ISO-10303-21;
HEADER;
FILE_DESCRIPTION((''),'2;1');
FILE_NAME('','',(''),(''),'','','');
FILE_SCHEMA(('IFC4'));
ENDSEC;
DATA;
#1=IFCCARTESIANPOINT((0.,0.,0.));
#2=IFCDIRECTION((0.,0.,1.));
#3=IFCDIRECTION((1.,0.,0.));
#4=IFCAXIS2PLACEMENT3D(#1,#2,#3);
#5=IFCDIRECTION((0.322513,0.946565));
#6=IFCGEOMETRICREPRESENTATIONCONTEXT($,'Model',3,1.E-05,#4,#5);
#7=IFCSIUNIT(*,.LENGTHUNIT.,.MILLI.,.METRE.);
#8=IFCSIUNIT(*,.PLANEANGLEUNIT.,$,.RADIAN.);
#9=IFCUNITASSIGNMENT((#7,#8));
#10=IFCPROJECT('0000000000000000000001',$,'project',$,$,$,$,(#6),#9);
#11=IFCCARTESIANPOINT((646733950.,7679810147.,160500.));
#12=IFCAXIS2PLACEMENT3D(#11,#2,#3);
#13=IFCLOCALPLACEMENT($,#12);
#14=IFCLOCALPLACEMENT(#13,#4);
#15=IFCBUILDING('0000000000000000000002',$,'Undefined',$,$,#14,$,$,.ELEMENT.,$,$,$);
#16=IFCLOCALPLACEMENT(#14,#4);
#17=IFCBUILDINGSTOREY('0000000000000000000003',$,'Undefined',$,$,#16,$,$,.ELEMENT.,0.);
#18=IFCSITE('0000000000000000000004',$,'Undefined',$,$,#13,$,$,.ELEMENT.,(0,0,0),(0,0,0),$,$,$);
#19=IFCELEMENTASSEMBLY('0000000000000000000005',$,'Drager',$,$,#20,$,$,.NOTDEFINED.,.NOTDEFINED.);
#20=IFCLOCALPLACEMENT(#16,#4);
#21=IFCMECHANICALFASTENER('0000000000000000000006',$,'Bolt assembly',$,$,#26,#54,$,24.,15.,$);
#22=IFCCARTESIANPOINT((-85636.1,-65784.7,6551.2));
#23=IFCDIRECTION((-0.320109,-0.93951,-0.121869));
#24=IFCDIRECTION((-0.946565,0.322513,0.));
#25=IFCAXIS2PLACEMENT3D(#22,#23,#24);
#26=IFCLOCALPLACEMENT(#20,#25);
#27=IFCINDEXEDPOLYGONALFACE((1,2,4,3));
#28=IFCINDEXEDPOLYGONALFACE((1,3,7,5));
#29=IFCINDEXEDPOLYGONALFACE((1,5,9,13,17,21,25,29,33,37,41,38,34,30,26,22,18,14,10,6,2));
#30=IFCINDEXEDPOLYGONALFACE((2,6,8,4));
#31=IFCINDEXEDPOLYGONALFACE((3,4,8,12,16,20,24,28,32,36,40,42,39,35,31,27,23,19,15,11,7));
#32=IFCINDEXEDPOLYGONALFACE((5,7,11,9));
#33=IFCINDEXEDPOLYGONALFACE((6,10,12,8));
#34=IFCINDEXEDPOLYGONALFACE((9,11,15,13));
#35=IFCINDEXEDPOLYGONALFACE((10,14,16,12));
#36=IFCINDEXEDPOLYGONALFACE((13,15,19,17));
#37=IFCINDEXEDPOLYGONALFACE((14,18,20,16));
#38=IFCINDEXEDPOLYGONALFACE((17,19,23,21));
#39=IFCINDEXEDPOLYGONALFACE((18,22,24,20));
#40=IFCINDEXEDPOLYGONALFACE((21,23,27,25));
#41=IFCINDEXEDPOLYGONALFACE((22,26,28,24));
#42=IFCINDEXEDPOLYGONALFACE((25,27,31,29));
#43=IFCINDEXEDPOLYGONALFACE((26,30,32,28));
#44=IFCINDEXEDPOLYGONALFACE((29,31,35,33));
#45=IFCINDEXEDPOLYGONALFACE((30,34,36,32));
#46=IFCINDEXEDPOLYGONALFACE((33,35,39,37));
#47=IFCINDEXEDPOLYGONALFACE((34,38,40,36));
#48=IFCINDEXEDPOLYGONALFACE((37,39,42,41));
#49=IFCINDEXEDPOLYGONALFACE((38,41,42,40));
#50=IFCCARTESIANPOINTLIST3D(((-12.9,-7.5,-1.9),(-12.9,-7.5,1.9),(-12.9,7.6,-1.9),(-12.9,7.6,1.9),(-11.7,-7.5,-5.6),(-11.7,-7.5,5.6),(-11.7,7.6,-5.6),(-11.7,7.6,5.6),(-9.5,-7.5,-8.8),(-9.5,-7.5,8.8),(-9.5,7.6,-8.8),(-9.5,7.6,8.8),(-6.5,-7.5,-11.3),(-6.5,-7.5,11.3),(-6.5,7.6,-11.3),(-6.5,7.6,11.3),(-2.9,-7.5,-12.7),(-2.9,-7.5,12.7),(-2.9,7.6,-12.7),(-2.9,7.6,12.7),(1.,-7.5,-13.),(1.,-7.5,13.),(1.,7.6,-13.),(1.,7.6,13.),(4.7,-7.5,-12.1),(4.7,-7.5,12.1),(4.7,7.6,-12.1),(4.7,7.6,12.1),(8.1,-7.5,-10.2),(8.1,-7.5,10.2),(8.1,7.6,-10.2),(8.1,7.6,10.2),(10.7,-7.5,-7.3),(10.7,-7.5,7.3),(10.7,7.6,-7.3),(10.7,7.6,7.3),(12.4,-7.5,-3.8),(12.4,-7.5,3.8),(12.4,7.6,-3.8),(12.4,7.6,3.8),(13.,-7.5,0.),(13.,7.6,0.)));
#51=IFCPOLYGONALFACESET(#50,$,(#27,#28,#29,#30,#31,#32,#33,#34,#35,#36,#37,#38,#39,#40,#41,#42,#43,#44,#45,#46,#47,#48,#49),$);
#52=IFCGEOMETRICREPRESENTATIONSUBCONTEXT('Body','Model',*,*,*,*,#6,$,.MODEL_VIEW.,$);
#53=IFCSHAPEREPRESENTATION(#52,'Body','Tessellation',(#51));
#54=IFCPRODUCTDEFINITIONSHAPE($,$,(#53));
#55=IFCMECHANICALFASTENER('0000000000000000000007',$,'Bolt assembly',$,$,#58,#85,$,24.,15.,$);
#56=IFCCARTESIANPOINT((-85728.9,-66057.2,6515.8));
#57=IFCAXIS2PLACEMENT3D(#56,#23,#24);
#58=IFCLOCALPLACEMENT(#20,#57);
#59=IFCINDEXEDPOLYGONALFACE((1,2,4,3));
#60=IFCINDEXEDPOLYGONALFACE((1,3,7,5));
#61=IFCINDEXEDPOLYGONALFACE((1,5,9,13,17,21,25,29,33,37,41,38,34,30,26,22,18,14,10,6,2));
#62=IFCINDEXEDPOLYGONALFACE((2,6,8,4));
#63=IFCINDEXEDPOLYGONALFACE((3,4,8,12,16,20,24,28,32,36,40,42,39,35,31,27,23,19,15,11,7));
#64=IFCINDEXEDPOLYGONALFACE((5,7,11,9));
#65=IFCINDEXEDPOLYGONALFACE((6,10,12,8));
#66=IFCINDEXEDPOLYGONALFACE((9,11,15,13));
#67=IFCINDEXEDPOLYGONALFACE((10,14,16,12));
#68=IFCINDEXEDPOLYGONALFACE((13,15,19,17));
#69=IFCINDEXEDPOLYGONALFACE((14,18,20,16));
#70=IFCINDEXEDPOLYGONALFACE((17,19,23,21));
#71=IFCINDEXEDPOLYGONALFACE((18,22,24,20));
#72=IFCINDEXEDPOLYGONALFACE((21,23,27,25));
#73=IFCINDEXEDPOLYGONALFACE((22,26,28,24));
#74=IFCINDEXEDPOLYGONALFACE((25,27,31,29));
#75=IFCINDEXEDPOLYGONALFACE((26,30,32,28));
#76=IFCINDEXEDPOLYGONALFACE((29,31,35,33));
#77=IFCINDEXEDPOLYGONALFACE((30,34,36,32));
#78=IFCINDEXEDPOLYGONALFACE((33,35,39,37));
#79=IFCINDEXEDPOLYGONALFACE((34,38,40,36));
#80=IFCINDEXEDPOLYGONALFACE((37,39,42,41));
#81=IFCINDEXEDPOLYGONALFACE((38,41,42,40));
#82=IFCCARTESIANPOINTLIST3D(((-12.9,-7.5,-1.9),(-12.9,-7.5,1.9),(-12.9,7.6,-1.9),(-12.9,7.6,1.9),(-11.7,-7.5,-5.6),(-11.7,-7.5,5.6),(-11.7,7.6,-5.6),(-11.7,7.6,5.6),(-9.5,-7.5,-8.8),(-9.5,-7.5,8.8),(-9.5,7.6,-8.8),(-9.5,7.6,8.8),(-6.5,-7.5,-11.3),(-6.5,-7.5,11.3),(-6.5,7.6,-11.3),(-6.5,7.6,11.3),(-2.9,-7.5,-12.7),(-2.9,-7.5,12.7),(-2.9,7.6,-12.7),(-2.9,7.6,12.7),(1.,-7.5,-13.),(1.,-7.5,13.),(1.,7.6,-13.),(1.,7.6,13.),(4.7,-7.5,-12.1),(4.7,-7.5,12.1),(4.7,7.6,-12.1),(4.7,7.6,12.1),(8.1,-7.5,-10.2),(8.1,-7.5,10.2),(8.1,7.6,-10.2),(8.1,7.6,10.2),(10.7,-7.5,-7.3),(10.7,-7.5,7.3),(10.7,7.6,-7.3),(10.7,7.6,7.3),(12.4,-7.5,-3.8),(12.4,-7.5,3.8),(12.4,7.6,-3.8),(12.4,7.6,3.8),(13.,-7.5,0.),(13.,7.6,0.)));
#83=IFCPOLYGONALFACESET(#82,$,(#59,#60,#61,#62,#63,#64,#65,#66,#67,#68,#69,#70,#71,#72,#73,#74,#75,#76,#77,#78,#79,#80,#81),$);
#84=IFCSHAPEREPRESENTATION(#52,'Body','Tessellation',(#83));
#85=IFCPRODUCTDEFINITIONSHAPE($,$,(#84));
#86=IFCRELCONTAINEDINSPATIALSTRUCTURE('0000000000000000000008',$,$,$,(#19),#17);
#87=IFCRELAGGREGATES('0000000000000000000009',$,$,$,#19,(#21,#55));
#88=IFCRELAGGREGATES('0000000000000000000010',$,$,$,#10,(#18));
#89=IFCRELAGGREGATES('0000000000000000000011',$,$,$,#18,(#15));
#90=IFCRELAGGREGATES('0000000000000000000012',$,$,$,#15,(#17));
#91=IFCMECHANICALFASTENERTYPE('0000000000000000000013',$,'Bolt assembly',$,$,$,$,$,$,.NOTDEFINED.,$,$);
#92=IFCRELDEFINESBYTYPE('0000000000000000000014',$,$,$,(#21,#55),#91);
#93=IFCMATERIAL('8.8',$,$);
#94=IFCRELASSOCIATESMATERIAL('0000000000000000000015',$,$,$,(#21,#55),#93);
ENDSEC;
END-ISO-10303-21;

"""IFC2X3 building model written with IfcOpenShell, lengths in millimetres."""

from ifc_helpers import new_model, si_unit, direction, frame, origin_with_axes, origin_2d_with_axis, place, context, subcontext, project, spatial, circle, extrude, source, transform, mapped, material, type_object, element, aggregate, save


model = new_model("IFC2X3")

# Units and contexts
model_context = context("Model", 3, precision=1e-05, world=origin_with_axes(), true_north=direction((0.322513, 0.946565)))
body_context = subcontext(model_context, "Body", "Model", "MODEL_VIEW")
ifc_project = project(units=[si_unit("LENGTHUNIT", "METRE", prefix="MILLI"), si_unit("PLANEANGLEUNIT", "RADIAN")], contexts=[model_context])

# Site, building, storey
site_placement = place(None, frame((646733950.0, 7679810147.0, 160500.0), z_axis=(0.0, 0.0, 1.0), x_axis=(1.0, 0.0, 0.0)))
site = spatial("IfcSite", under=ifc_project, at=site_placement, Name="Undefined", CompositionType="ELEMENT", RefLatitude=(0, 0, 0), RefLongitude=(0, 0, 0))
building_placement = place(site_placement, origin_with_axes())
building = spatial("IfcBuilding", under=site, at=building_placement, Name="Undefined", CompositionType="ELEMENT")
storey_placement = place(building_placement, origin_with_axes())
storey = spatial("IfcBuildingStorey", under=building, at=storey_placement, Name="Undefined", CompositionType="ELEMENT", Elevation=0.0)

# Element assembly
assembly_1_placement = place(storey_placement, origin_with_axes())
assembly_1 = element("IfcElementAssembly", 1, at=assembly_1_placement, inside=storey, Name="Drager", AssemblyPlace="NOTDEFINED", PredefinedType="NOTDEFINED")

# Mechanical fasteners
ifc_material_1 = material(Name="8.8")
mechanical_fastener_type = type_object("IfcMechanicalFastenerType", Name="Bolt assembly")
shared_shape_1 = source(origin_with_axes(), body_context, "Body", "SweptSolid", [
    extrude(circle(Radius=13.0, at=origin_2d_with_axis()), frame((0.0, -7.5, 0.0), z_axis=(0.0, 1.0, 0.0), x_axis=(1.0, 0.0, 0.0)), (0.0, 0.0, 1.0), 15.1),
])
mechanical_fastener_1_placement = place(assembly_1_placement, frame((-85636.1, -65784.7, 6551.2), z_axis=(-0.320109, -0.93951, -0.121869), x_axis=(-0.946565, 0.322513, 0.0)))
mechanical_fastener_1 = element("IfcMechanicalFastener", 2, at=mechanical_fastener_1_placement, type_object=mechanical_fastener_type, material=ifc_material_1, Name="Bolt assembly", NominalDiameter=24.0, NominalLength=15.0, context=body_context, shape_type="MappedRepresentation", body=[
    mapped(shared_shape_1, transform((0.0, 0.0, 0.0))),
])
mechanical_fastener_2_placement = place(assembly_1_placement, frame((-85728.9, -66057.2, 6515.8), z_axis=(-0.320109, -0.93951, -0.121869), x_axis=(-0.946565, 0.322513, 0.0)))
mechanical_fastener_2 = element("IfcMechanicalFastener", 3, at=mechanical_fastener_2_placement, type_object=mechanical_fastener_type, material=ifc_material_1, Name="Bolt assembly", NominalDiameter=24.0, NominalLength=15.0, context=body_context, shape_type="MappedRepresentation", body=[
    mapped(shared_shape_1, transform((0.0, 0.0, 0.0))),
])
aggregate(assembly_1, [mechanical_fastener_1, mechanical_fastener_2])

save(model, "model.ifc")
